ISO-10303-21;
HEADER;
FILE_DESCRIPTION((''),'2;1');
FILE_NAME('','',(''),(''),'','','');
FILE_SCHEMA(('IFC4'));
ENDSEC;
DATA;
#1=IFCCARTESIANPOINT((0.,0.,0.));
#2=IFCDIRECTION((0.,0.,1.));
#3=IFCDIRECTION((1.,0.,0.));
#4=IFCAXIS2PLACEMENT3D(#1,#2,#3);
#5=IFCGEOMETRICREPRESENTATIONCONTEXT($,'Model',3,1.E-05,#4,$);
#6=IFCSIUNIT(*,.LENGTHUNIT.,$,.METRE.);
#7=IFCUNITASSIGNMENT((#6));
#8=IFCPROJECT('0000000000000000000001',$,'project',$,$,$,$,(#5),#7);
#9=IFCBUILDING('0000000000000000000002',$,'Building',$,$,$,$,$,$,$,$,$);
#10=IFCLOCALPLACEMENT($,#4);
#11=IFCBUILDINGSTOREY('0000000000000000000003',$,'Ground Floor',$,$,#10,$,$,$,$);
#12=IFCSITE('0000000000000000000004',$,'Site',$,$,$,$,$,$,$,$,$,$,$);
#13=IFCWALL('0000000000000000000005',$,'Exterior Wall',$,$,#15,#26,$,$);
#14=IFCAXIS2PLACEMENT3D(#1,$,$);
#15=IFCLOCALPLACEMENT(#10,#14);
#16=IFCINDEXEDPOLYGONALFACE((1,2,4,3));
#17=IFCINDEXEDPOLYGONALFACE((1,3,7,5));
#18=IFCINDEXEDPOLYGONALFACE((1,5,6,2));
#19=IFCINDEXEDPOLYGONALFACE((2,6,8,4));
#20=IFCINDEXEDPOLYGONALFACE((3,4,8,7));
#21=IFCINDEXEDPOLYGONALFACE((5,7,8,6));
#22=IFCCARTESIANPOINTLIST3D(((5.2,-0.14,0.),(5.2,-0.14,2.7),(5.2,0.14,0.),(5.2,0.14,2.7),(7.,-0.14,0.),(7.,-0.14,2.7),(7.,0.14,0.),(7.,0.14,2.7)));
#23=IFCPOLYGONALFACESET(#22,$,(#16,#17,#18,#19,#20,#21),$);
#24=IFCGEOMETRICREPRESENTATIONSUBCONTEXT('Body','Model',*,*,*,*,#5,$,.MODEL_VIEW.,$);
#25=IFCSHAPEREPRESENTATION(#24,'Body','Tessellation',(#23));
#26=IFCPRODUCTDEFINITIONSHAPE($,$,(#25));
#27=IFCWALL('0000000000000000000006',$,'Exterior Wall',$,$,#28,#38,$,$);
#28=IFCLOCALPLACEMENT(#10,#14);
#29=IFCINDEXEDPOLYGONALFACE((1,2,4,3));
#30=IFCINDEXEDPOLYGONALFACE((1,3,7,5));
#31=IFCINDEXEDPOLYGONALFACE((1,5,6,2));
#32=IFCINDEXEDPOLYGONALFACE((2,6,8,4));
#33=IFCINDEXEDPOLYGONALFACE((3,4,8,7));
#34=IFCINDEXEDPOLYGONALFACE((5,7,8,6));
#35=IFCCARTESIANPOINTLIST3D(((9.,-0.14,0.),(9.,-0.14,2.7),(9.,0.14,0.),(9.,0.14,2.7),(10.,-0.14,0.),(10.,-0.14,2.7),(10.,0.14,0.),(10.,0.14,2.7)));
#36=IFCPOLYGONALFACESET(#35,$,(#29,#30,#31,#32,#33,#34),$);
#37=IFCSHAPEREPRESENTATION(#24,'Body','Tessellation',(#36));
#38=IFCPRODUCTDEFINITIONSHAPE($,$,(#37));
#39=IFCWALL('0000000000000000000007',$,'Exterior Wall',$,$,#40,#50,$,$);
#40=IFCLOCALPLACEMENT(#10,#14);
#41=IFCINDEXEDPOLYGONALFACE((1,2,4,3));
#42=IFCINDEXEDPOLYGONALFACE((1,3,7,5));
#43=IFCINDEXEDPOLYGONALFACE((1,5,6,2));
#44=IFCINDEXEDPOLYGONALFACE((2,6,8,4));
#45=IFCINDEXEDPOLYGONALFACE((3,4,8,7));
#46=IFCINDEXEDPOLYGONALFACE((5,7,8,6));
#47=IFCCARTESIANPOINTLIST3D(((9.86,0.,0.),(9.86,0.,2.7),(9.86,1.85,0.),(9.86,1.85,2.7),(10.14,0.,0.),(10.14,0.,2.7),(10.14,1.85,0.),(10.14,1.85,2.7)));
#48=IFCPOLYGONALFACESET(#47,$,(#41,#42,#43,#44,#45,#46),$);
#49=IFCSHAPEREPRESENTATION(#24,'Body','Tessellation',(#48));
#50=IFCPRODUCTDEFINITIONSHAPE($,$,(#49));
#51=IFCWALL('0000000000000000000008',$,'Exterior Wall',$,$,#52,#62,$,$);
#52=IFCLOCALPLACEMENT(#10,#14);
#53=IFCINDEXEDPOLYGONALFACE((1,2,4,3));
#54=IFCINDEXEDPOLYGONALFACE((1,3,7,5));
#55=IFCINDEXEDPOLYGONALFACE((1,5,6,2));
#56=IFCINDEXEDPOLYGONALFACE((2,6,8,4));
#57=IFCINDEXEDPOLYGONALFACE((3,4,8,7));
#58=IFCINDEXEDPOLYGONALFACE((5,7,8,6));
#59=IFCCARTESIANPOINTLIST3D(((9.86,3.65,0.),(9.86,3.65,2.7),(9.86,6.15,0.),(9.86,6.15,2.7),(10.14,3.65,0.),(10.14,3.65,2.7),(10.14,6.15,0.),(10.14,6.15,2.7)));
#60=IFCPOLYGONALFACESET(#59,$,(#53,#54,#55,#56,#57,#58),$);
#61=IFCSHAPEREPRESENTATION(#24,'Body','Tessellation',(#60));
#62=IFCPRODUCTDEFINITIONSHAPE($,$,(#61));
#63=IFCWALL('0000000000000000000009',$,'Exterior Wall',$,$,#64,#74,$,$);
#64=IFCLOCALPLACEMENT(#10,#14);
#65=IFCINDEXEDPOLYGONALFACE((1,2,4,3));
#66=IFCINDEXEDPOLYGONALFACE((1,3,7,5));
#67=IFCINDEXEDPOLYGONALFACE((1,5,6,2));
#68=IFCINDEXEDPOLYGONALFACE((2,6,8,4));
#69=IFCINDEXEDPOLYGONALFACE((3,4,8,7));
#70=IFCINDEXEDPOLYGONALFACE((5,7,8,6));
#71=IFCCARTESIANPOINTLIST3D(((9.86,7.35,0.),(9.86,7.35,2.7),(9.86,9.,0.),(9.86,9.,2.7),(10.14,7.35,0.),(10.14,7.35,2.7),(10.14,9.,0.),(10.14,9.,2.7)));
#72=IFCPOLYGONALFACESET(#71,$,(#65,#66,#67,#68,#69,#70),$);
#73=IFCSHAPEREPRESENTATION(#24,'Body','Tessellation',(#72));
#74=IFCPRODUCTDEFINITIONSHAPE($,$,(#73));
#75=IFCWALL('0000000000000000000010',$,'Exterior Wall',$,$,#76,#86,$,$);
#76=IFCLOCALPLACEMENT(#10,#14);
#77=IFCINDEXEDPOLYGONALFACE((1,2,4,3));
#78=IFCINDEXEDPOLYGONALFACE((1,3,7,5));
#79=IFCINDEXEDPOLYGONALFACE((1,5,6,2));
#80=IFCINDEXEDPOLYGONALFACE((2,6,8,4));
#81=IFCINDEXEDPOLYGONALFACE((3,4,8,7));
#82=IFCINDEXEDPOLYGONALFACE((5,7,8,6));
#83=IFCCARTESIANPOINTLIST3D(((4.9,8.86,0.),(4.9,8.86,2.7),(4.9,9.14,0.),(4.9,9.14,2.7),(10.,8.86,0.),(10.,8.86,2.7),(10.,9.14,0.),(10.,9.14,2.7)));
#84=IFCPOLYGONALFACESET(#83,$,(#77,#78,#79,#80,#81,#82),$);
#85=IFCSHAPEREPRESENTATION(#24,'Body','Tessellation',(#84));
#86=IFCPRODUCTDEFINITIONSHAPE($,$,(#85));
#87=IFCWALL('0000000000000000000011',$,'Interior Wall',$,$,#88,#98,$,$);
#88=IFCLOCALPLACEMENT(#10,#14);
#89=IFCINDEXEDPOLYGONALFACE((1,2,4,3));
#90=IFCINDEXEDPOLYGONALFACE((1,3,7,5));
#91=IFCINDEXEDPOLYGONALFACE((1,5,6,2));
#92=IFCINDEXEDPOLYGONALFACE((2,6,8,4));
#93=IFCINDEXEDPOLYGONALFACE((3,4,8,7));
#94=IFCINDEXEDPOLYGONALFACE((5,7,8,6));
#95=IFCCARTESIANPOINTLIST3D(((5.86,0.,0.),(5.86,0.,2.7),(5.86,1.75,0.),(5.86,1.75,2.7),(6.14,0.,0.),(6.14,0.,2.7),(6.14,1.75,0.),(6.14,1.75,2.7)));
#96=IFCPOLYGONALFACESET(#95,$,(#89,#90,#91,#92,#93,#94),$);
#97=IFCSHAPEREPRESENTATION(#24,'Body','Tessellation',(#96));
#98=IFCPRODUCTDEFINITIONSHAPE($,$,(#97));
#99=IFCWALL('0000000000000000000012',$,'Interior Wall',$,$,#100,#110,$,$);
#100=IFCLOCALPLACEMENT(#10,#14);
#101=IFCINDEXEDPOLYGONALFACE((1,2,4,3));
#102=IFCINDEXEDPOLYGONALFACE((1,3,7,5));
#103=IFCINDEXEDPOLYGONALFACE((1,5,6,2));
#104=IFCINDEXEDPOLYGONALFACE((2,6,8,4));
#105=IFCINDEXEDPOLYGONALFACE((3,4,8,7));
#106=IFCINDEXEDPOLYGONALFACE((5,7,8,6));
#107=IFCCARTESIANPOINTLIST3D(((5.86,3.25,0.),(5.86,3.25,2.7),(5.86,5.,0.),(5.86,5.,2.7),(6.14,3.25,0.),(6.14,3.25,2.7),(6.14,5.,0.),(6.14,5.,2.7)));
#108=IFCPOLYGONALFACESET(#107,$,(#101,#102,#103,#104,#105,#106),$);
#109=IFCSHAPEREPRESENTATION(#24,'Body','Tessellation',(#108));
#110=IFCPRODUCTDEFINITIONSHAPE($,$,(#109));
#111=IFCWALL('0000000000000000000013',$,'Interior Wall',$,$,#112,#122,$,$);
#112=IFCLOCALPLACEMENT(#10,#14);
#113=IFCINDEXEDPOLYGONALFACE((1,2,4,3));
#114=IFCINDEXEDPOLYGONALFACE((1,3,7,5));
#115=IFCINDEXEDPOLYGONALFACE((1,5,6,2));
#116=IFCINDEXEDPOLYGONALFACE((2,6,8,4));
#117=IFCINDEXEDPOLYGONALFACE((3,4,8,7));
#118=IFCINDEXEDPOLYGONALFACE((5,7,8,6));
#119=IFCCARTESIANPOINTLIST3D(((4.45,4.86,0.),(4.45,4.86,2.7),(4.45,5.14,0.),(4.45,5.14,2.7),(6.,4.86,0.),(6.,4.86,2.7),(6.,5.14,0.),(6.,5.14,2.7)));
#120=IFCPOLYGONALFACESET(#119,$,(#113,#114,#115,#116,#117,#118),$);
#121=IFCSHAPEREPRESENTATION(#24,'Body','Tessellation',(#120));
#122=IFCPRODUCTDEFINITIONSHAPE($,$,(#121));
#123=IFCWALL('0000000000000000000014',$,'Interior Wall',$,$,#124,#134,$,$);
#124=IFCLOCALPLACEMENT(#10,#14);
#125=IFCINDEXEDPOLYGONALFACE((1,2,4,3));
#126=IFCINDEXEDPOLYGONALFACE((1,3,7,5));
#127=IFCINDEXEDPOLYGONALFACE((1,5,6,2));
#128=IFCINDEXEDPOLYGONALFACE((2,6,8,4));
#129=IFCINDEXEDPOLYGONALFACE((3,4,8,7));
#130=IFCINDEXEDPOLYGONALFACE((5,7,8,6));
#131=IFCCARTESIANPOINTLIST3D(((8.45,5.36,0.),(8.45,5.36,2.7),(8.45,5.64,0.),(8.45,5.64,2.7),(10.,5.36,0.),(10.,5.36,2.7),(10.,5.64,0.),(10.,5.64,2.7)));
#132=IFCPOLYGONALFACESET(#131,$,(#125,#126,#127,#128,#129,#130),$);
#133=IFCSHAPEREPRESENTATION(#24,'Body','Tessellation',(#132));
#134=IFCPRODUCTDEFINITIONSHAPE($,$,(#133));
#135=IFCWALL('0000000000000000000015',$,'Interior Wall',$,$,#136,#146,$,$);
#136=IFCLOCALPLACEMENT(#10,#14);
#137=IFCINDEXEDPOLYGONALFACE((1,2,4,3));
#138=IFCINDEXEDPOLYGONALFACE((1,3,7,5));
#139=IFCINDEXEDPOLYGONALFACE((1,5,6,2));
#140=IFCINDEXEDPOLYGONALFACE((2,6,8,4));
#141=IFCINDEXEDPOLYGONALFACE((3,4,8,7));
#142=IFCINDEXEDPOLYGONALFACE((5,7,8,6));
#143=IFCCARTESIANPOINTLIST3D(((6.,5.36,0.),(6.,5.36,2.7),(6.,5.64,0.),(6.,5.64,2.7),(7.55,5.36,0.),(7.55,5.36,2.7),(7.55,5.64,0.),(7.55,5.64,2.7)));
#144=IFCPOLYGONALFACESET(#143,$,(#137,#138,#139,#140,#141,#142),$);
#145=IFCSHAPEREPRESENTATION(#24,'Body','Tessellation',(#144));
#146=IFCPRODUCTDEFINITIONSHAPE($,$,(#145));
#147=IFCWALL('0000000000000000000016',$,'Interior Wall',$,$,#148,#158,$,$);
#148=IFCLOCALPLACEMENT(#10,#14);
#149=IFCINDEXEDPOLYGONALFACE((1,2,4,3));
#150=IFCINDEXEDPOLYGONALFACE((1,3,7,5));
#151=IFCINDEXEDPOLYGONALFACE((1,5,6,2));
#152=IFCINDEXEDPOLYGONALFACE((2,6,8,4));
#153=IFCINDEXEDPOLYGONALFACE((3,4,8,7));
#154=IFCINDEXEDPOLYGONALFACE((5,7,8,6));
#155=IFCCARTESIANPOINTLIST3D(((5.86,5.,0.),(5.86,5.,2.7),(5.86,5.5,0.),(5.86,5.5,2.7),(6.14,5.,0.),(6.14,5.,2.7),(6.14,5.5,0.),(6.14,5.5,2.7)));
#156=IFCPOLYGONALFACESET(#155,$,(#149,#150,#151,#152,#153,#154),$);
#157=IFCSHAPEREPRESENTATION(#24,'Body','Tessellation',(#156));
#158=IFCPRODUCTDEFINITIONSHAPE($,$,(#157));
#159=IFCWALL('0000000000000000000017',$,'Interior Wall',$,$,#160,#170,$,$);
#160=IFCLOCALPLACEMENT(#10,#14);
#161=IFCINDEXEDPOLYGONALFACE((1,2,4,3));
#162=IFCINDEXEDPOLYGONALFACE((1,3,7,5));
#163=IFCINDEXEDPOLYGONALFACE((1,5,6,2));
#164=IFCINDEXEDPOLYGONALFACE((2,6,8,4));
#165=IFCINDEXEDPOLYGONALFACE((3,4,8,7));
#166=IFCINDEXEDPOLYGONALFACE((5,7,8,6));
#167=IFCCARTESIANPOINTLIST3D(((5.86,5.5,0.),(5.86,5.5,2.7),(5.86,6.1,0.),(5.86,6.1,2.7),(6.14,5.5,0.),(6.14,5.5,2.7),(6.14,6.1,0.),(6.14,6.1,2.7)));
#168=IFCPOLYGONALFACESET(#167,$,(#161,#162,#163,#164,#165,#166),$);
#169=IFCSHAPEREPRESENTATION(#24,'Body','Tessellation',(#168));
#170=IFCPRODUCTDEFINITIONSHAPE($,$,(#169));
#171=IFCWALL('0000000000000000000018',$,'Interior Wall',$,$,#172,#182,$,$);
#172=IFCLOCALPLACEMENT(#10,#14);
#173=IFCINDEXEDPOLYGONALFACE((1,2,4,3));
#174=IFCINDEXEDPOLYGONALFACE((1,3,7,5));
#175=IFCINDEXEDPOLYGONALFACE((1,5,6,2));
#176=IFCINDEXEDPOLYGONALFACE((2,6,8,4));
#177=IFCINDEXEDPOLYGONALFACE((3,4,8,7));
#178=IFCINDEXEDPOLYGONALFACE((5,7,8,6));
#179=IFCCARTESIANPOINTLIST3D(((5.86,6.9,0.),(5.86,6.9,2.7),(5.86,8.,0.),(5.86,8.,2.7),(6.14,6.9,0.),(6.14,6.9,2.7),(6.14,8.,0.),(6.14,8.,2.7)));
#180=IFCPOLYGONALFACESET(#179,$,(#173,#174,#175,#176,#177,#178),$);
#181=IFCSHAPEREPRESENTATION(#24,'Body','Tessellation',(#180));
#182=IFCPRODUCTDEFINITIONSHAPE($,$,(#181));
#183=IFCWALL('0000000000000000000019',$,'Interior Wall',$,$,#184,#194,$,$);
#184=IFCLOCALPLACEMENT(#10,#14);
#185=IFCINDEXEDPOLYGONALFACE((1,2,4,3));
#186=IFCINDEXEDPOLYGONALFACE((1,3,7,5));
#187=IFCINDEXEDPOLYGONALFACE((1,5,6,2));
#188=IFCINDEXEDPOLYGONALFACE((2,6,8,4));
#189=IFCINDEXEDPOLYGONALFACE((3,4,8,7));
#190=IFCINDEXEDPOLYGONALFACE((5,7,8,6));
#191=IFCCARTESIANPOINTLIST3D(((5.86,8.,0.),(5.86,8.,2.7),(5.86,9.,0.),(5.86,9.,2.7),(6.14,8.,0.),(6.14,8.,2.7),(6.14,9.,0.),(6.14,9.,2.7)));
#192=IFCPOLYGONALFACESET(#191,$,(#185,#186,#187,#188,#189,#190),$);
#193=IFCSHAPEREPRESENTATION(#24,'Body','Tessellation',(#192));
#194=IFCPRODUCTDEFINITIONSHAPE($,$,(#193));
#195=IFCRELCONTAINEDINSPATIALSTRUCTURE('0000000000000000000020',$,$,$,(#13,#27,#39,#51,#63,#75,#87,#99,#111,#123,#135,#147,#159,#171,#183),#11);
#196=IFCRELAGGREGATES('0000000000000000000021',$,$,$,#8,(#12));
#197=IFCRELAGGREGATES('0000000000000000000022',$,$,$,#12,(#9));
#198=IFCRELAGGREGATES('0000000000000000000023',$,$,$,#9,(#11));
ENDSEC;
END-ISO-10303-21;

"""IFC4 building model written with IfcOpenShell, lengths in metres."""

from ifc_helpers import new_model, si_unit, frame, origin_with_axes, place, context, subcontext, project, spatial, indexed_curve, outline, extrude, element, save


model = new_model("IFC4")

# Units and contexts
model_context = context("Model", 3, precision=1e-05, world=origin_with_axes())
body_context = subcontext(model_context, "Body", "Model", "MODEL_VIEW")
ifc_project = project(units=[si_unit("LENGTHUNIT", "METRE")], contexts=[model_context])

# Site, building, storey
site = spatial("IfcSite", under=ifc_project, Name="Site")
building = spatial("IfcBuilding", under=site, Name="Building")
storey_placement = place(None, origin_with_axes())
storey = spatial("IfcBuildingStorey", under=building, at=storey_placement, Name="Ground Floor")

# Walls
wall_1_placement = place(storey_placement, frame((5.2, 0.0, 0.0), z_axis=(0.0, 0.0, 1.0), x_axis=(1.0, 0.0, 0.0)))
element("IfcWall", 1, at=wall_1_placement, inside=storey, Name="Exterior Wall", context=body_context, shape_type="SweptSolid", body=[
    extrude(outline(indexed_curve([(0.0, 0.0), (0.0, 0.28), (1.8, 0.28), (1.8, 0.0), (0.0, 0.0)], self_intersect=False)), frame((0.0, -0.14, 0.0), z_axis=(0.0, 0.0, 1.0), x_axis=(1.0, 0.0, 0.0)), (0.0, 0.0, 1.0), 2.7),
])
wall_2_placement = place(storey_placement, frame((9.0, 0.0, 0.0), z_axis=(0.0, 0.0, 1.0), x_axis=(1.0, 0.0, 0.0)))
element("IfcWall", 2, at=wall_2_placement, inside=storey, Name="Exterior Wall", context=body_context, shape_type="SweptSolid", body=[
    extrude(outline(indexed_curve([(0.0, 0.0), (0.0, 0.28), (1.0, 0.28), (1.0, 0.0), (0.0, 0.0)], self_intersect=False)), frame((0.0, -0.14, 0.0), z_axis=(0.0, 0.0, 1.0), x_axis=(1.0, 0.0, 0.0)), (0.0, 0.0, 1.0), 2.7),
])
wall_3_placement = place(storey_placement, frame((10.0, 0.0, 0.0), z_axis=(0.0, 0.0, 1.0), x_axis=(0.0, 1.0, 0.0)))
element("IfcWall", 3, at=wall_3_placement, inside=storey, Name="Exterior Wall", context=body_context, shape_type="SweptSolid", body=[
    extrude(outline(indexed_curve([(0.0, 0.0), (0.0, 0.28), (1.85, 0.28), (1.85, 0.0), (0.0, 0.0)], self_intersect=False)), frame((0.0, -0.14, 0.0), z_axis=(0.0, 0.0, 1.0), x_axis=(1.0, 0.0, 0.0)), (0.0, 0.0, 1.0), 2.7),
])
wall_4_placement = place(storey_placement, frame((10.0, 3.65, 0.0), z_axis=(0.0, 0.0, 1.0), x_axis=(0.0, 1.0, 0.0)))
element("IfcWall", 4, at=wall_4_placement, inside=storey, Name="Exterior Wall", context=body_context, shape_type="SweptSolid", body=[
    extrude(outline(indexed_curve([(0.0, 0.0), (0.0, 0.28), (2.5, 0.28), (2.5, 0.0), (0.0, 0.0)], self_intersect=False)), frame((0.0, -0.14, 0.0), z_axis=(0.0, 0.0, 1.0), x_axis=(1.0, 0.0, 0.0)), (0.0, 0.0, 1.0), 2.7),
])
wall_5_placement = place(storey_placement, frame((10.0, 7.35, 0.0), z_axis=(0.0, 0.0, 1.0), x_axis=(0.0, 1.0, 0.0)))
element("IfcWall", 5, at=wall_5_placement, inside=storey, Name="Exterior Wall", context=body_context, shape_type="SweptSolid", body=[
    extrude(outline(indexed_curve([(0.0, 0.0), (0.0, 0.28), (1.65, 0.28), (1.65, 0.0), (0.0, 0.0)], self_intersect=False)), frame((0.0, -0.14, 0.0), z_axis=(0.0, 0.0, 1.0), x_axis=(1.0, 0.0, 0.0)), (0.0, 0.0, 1.0), 2.7),
])
wall_6_placement = place(storey_placement, frame((10.0, 9.0, 0.0), z_axis=(0.0, 0.0, 1.0), x_axis=(-1.0, 0.0, 0.0)))
element("IfcWall", 6, at=wall_6_placement, inside=storey, Name="Exterior Wall", context=body_context, shape_type="SweptSolid", body=[
    extrude(outline(indexed_curve([(0.0, 0.0), (0.0, 0.28), (5.1, 0.28), (5.1, 0.0), (0.0, 0.0)], self_intersect=False)), frame((0.0, -0.14, 0.0), z_axis=(0.0, 0.0, 1.0), x_axis=(1.0, 0.0, 0.0)), (0.0, 0.0, 1.0), 2.7),
])
for number, where, z_axis, x_axis, name in (
    (7, (6.0, 0.0, 0.0), (0.0, 0.0, 1.0), (0.0, 1.0, 0.0), "Interior Wall"),
    (8, (6.0, 3.25, 0.0), (0.0, 0.0, 1.0), (0.0, 1.0, 0.0), "Interior Wall"),
):
    element("IfcWall", number, at=place(storey_placement, frame(where, z_axis=z_axis, x_axis=x_axis)), inside=storey, Name=name, context=body_context, shape_type="SweptSolid", body=[
        extrude(outline(indexed_curve([(0.0, 0.0), (0.0, 0.28), (1.75, 0.28), (1.75, 0.0), (0.0, 0.0)], self_intersect=False)), frame((0.0, -0.14, 0.0), z_axis=(0.0, 0.0, 1.0), x_axis=(1.0, 0.0, 0.0)), (0.0, 0.0, 1.0), 2.7),
    ])
wall_7_placement = place(storey_placement, frame((6.0, 5.0, 0.0), z_axis=(0.0, 0.0, 1.0), x_axis=(-1.0, 0.0, 0.0)))
element("IfcWall", 9, at=wall_7_placement, inside=storey, Name="Interior Wall", context=body_context, shape_type="SweptSolid", body=[
    extrude(outline(indexed_curve([(0.0, 0.0), (0.0, 0.28), (1.55, 0.28), (1.55, 0.0), (0.0, 0.0)], self_intersect=False)), frame((0.0, -0.14, 0.0), z_axis=(0.0, 0.0, 1.0), x_axis=(1.0, 0.0, 0.0)), (0.0, 0.0, 1.0), 2.7),
])
wall_8_placement = place(storey_placement, frame((10.0, 5.5, 0.0), z_axis=(0.0, 0.0, 1.0), x_axis=(-1.0, 0.0, 0.0)))
element("IfcWall", 10, at=wall_8_placement, inside=storey, Name="Interior Wall", context=body_context, shape_type="SweptSolid", body=[
    extrude(outline(indexed_curve([(0.0, 0.0), (0.0, 0.28), (1.55, 0.28), (1.55, 0.0), (0.0, 0.0)], self_intersect=False)), frame((0.0, -0.14, 0.0), z_axis=(0.0, 0.0, 1.0), x_axis=(1.0, 0.0, 0.0)), (0.0, 0.0, 1.0), 2.7),
])
wall_9_placement = place(storey_placement, frame((7.55, 5.5, 0.0), z_axis=(0.0, 0.0, 1.0), x_axis=(-1.0, 0.0, 0.0)))
element("IfcWall", 11, at=wall_9_placement, inside=storey, Name="Interior Wall", context=body_context, shape_type="SweptSolid", body=[
    extrude(outline(indexed_curve([(0.0, 0.0), (0.0, 0.28), (1.55, 0.28), (1.55, 0.0), (0.0, 0.0)], self_intersect=False)), frame((0.0, -0.14, 0.0), z_axis=(0.0, 0.0, 1.0), x_axis=(1.0, 0.0, 0.0)), (0.0, 0.0, 1.0), 2.7),
])
wall_10_placement = place(storey_placement, frame((6.0, 5.5, 0.0), z_axis=(0.0, 0.0, 1.0), x_axis=(0.0, -1.0, 0.0)))
element("IfcWall", 12, at=wall_10_placement, inside=storey, Name="Interior Wall", context=body_context, shape_type="SweptSolid", body=[
    extrude(outline(indexed_curve([(0.0, 0.0), (0.0, 0.28), (0.5, 0.28), (0.5, 0.0), (0.0, 0.0)], self_intersect=False)), frame((0.0, -0.14, 0.0), z_axis=(0.0, 0.0, 1.0), x_axis=(1.0, 0.0, 0.0)), (0.0, 0.0, 1.0), 2.7),
])
wall_11_placement = place(storey_placement, frame((6.0, 5.5, 0.0), z_axis=(0.0, 0.0, 1.0), x_axis=(0.0, 1.0, 0.0)))
element("IfcWall", 13, at=wall_11_placement, inside=storey, Name="Interior Wall", context=body_context, shape_type="SweptSolid", body=[
    extrude(outline(indexed_curve([(0.0, 0.0), (0.0, 0.28), (0.6, 0.28), (0.6, 0.0), (0.0, 0.0)], self_intersect=False)), frame((0.0, -0.14, 0.0), z_axis=(0.0, 0.0, 1.0), x_axis=(1.0, 0.0, 0.0)), (0.0, 0.0, 1.0), 2.7),
])
wall_12_placement = place(storey_placement, frame((6.0, 6.9, 0.0), z_axis=(0.0, 0.0, 1.0), x_axis=(0.0, 1.0, 0.0)))
element("IfcWall", 14, at=wall_12_placement, inside=storey, Name="Interior Wall", context=body_context, shape_type="SweptSolid", body=[
    extrude(outline(indexed_curve([(0.0, 0.0), (0.0, 0.28), (1.1, 0.28), (1.1, 0.0), (0.0, 0.0)], self_intersect=False)), frame((0.0, -0.14, 0.0), z_axis=(0.0, 0.0, 1.0), x_axis=(1.0, 0.0, 0.0)), (0.0, 0.0, 1.0), 2.7),
])
wall_13_placement = place(storey_placement, frame((6.0, 8.0, 0.0), z_axis=(0.0, 0.0, 1.0), x_axis=(0.0, 1.0, 0.0)))
element("IfcWall", 15, at=wall_13_placement, inside=storey, Name="Interior Wall", context=body_context, shape_type="SweptSolid", body=[
    extrude(outline(indexed_curve([(0.0, 0.0), (0.0, 0.28), (1.0, 0.28), (1.0, 0.0), (0.0, 0.0)], self_intersect=False)), frame((0.0, -0.14, 0.0), z_axis=(0.0, 0.0, 1.0), x_axis=(1.0, 0.0, 0.0)), (0.0, 0.0, 1.0), 2.7),
])

save(model, "model.ifc")
